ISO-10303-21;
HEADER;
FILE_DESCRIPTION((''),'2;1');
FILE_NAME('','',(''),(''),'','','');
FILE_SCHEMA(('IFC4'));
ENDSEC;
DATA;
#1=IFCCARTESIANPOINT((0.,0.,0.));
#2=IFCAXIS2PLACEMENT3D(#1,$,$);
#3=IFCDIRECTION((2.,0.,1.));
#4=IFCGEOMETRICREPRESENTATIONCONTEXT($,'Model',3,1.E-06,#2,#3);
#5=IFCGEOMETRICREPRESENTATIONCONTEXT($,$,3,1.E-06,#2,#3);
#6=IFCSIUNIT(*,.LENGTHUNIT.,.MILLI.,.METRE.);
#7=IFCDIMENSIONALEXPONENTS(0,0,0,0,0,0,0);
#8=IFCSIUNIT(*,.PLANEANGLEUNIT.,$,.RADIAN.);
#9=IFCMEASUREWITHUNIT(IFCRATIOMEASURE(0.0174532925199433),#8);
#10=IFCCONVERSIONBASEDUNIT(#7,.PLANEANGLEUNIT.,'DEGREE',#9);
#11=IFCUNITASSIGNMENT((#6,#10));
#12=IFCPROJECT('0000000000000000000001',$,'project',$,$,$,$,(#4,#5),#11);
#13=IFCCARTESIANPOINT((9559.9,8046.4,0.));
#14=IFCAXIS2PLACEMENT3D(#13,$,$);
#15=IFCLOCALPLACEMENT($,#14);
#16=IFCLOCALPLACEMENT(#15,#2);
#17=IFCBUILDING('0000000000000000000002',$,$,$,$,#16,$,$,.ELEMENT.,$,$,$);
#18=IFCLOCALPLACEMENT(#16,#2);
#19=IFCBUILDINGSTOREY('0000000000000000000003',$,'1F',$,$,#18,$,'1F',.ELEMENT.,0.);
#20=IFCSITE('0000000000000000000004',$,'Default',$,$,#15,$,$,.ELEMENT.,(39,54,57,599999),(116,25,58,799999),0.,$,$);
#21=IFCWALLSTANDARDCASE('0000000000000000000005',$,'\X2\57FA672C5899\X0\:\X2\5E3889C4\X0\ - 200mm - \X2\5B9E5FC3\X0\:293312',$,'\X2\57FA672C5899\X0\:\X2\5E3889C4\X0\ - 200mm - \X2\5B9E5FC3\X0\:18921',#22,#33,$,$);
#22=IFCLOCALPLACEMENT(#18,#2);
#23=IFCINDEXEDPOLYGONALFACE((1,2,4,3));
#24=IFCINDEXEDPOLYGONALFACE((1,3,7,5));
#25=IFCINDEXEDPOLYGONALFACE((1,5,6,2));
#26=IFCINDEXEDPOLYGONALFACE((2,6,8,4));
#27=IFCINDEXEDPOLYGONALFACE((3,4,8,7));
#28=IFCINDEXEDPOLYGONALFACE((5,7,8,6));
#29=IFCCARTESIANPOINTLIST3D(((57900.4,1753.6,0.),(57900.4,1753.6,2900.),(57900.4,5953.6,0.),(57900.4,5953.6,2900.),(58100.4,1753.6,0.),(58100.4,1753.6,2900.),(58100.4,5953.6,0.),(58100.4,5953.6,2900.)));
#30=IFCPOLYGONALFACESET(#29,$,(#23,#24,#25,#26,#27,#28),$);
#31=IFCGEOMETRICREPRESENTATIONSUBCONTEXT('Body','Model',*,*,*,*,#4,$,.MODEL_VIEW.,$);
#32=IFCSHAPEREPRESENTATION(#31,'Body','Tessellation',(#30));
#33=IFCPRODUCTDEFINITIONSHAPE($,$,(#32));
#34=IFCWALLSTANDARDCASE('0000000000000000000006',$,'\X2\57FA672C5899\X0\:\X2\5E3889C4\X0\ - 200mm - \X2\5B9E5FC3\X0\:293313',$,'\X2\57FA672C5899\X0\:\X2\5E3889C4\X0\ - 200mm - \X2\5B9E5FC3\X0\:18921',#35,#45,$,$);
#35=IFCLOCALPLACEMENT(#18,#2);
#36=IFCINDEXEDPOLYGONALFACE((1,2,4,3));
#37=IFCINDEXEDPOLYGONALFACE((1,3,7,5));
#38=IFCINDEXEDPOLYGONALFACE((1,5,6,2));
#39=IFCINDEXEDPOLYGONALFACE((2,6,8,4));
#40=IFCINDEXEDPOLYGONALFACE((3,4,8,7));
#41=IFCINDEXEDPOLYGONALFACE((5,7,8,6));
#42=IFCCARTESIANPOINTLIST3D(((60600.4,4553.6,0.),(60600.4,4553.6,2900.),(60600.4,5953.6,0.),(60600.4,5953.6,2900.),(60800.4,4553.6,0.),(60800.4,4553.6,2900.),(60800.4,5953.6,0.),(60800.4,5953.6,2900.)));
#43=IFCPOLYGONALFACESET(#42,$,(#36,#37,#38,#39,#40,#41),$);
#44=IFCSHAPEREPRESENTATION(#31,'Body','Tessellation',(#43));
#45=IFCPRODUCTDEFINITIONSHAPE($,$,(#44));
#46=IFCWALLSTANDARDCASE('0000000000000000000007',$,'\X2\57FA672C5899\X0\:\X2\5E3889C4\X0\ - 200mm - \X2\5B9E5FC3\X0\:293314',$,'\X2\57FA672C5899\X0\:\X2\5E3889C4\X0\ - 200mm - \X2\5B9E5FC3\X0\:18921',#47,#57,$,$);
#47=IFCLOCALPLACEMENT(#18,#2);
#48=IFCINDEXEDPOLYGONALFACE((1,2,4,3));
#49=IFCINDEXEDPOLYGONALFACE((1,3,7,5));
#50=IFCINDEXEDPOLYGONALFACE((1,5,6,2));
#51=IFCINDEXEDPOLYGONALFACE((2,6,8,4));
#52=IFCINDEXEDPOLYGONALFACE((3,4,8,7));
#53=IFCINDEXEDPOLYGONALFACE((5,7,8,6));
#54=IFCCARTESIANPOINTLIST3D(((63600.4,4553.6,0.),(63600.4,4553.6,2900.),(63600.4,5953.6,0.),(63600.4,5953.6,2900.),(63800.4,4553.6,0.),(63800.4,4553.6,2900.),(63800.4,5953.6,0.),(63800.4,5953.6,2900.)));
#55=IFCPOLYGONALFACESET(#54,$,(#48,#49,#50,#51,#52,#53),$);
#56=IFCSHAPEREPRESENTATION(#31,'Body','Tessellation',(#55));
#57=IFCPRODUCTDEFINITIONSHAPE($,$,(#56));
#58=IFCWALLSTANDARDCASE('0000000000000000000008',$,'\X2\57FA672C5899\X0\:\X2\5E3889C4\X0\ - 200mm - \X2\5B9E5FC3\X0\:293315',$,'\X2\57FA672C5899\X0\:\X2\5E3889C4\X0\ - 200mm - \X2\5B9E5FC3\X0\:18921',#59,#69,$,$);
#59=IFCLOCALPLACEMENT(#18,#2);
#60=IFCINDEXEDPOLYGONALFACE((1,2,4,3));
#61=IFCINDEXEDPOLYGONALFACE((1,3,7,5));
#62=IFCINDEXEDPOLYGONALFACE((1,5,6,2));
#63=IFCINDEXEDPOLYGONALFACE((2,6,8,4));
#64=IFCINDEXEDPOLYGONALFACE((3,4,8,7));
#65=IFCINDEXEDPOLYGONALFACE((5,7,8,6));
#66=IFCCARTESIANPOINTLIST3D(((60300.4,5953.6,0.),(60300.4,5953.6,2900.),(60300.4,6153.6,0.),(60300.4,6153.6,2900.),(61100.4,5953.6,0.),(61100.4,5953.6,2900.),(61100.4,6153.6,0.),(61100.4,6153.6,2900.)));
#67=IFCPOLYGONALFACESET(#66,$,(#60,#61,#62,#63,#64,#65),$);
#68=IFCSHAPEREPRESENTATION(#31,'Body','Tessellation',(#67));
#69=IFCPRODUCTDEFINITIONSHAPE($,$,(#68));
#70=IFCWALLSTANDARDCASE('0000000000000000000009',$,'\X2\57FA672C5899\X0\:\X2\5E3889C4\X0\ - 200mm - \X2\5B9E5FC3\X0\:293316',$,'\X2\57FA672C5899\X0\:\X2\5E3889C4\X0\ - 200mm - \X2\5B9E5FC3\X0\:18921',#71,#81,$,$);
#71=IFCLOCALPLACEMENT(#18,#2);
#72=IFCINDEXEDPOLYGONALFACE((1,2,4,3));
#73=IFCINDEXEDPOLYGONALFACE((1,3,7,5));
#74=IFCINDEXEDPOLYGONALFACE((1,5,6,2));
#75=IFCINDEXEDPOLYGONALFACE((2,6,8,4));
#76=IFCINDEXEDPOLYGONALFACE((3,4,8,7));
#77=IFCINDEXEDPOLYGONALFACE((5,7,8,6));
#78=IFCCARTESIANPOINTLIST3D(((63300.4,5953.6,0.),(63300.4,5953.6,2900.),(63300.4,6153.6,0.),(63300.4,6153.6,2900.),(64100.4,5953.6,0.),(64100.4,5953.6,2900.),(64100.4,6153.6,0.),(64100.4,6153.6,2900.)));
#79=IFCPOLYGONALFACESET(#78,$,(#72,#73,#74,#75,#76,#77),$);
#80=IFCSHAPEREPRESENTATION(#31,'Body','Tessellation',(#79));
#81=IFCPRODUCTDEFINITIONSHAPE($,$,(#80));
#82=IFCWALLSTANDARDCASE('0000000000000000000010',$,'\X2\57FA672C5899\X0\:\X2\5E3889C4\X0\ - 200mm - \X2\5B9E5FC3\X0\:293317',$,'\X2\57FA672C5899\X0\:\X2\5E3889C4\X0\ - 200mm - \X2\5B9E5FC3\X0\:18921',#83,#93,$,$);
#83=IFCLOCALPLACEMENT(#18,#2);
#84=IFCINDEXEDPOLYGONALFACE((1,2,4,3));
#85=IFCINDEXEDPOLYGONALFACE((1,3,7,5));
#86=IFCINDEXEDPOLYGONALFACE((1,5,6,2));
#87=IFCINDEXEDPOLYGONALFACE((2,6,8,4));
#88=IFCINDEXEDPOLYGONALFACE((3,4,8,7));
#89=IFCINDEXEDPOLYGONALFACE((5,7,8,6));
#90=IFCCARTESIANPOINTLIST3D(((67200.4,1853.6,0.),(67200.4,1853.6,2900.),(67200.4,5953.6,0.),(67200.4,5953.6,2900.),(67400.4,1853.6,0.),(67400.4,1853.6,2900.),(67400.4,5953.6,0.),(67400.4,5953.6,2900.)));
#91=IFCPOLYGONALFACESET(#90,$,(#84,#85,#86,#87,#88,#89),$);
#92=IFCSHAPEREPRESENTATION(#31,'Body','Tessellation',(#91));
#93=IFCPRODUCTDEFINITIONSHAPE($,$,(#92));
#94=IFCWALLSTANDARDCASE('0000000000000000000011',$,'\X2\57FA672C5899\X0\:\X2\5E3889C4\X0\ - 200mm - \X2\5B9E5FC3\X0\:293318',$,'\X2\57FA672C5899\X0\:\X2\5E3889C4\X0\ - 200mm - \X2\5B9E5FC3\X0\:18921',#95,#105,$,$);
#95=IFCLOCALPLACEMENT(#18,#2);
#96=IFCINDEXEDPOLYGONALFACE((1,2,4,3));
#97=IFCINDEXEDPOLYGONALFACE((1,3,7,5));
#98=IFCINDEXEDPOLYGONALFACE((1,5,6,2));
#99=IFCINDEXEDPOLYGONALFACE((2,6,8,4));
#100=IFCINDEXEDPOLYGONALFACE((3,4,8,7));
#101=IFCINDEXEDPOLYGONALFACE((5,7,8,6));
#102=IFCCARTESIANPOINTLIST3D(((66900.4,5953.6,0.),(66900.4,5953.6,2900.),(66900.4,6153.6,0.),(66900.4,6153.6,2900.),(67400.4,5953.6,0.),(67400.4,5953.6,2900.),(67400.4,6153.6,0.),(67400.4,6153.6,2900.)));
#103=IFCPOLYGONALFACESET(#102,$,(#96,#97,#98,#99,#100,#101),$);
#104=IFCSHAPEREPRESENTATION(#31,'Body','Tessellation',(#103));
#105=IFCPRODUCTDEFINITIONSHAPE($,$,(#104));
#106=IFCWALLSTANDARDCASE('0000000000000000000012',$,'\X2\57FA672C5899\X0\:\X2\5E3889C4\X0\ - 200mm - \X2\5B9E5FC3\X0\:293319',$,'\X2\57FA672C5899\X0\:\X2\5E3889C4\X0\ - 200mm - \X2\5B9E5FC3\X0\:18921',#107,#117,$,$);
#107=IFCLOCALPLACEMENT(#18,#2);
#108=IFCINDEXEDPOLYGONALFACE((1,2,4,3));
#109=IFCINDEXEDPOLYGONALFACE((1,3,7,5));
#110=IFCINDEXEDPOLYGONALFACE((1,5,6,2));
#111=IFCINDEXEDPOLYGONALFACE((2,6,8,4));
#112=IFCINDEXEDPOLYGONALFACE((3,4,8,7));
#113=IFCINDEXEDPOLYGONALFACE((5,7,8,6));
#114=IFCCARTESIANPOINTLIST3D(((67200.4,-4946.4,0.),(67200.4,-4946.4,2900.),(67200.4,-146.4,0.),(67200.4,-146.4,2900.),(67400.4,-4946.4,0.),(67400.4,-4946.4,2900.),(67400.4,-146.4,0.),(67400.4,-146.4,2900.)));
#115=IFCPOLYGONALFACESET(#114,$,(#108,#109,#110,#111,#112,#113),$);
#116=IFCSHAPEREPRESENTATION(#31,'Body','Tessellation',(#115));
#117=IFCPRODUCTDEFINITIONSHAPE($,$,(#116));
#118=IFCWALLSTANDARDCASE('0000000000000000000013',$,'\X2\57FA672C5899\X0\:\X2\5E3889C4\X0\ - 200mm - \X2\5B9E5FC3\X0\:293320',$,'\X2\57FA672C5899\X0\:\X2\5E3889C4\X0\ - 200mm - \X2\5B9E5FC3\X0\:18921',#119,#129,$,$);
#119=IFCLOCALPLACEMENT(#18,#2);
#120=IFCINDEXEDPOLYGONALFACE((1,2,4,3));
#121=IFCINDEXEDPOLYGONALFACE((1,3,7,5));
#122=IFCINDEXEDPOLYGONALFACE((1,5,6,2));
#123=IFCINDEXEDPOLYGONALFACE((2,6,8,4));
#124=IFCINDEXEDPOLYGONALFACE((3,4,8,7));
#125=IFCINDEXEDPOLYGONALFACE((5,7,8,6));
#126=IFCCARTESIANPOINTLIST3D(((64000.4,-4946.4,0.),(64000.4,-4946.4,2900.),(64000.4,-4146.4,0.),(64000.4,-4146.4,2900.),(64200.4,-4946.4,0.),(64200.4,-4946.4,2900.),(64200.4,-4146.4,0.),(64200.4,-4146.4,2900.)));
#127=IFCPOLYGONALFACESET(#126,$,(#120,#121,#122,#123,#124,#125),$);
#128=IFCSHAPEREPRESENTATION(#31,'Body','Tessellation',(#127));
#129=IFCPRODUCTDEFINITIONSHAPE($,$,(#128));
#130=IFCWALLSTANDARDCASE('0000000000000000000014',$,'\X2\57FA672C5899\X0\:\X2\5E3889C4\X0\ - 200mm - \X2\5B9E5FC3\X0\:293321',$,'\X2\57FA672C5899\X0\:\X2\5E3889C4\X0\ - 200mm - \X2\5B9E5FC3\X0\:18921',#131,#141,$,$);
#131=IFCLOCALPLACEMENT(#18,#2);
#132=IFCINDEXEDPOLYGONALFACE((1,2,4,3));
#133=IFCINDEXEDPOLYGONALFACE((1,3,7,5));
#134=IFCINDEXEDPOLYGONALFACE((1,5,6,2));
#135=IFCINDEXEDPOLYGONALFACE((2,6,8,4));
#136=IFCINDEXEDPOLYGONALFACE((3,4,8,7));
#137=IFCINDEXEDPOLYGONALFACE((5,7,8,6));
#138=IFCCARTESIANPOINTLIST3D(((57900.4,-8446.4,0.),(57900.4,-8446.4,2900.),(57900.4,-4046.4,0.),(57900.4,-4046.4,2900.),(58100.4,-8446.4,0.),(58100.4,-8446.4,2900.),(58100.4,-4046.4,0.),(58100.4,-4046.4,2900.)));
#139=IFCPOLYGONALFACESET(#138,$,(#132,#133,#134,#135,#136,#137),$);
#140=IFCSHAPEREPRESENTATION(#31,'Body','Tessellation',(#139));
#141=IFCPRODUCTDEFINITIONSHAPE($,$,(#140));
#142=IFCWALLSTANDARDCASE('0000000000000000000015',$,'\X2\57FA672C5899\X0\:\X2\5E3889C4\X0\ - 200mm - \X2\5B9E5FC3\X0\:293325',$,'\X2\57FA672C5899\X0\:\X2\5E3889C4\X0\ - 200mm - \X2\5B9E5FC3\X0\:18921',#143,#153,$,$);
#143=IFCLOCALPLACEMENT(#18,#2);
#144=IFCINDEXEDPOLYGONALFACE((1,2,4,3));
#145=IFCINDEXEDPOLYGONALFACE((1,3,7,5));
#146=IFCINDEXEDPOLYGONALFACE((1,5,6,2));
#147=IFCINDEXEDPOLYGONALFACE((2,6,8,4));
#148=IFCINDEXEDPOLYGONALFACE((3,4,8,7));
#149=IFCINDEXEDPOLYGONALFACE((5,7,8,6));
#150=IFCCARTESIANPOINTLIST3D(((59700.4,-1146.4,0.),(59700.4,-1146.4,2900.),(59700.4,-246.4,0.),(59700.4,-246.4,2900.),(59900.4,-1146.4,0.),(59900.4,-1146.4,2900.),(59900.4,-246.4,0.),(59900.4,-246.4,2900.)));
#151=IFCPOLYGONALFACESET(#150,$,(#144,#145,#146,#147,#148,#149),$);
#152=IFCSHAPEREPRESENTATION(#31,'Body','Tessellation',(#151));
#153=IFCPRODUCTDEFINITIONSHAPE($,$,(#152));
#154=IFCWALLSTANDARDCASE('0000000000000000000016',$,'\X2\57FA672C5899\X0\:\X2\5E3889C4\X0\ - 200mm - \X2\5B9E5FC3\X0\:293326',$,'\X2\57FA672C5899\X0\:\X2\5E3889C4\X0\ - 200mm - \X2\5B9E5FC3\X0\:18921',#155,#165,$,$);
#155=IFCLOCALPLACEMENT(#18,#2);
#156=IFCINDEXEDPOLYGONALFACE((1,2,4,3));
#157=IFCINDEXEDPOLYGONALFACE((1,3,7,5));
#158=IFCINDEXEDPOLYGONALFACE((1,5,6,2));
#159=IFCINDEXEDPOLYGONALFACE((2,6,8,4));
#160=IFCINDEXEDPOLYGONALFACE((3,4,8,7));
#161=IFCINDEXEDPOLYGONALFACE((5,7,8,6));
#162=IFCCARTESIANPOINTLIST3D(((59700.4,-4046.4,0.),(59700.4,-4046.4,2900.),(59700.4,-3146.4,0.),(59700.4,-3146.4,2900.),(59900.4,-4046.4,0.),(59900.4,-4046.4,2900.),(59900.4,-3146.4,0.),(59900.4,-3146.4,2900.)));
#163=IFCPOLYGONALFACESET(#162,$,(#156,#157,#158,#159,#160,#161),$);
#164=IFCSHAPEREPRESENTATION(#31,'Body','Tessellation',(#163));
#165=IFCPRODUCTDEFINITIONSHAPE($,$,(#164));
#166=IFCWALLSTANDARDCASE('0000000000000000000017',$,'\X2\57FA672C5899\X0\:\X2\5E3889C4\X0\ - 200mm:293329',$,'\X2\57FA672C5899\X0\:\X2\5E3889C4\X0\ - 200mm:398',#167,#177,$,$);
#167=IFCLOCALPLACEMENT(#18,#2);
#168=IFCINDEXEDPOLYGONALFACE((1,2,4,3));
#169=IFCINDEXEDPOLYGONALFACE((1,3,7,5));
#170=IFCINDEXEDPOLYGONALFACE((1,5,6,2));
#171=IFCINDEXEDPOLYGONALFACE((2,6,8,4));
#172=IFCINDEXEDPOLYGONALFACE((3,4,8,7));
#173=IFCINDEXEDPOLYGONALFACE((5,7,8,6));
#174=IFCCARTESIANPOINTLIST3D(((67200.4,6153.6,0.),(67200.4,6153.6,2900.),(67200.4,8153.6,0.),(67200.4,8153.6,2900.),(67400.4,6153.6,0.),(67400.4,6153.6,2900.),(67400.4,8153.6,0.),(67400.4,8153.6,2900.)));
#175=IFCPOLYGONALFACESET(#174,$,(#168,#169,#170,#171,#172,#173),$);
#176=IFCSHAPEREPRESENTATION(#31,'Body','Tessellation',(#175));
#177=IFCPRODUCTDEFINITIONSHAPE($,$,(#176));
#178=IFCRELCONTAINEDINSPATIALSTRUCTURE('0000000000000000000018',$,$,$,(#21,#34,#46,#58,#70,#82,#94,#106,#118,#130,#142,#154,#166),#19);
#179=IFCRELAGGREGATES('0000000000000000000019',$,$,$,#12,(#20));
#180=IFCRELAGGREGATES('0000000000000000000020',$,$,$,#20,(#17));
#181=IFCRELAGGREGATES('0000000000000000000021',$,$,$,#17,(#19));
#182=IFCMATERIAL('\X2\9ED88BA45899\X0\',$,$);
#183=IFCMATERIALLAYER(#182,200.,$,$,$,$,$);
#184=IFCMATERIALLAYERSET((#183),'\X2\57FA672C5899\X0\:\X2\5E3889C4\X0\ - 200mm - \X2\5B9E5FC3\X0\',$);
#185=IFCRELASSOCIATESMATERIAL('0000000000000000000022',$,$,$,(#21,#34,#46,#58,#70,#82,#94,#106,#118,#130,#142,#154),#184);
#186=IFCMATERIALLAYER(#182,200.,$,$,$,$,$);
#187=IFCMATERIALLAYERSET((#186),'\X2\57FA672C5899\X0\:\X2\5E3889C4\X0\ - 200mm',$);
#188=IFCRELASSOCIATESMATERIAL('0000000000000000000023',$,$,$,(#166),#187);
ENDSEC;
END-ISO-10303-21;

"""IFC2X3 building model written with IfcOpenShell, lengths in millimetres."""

from ifc_helpers import new_model, entity, si_unit, converted_unit, direction, frame, frame_2d, origin, place, context, subcontext, project, spatial, rectangle, extrude, clip, halfspace, material, layer, layer_set, layer_usage, element, save


model = new_model("IFC2X3")

# Units and contexts
model_context = context("Model", 3, precision=1e-06, world=origin(), true_north=direction((2.0, 0.0, 1.0)))
context_of_model = context(None, 3, precision=1e-06, world=origin(), true_north=direction((2.0, 0.0, 1.0)))
body_context = subcontext(model_context, "Body", "Model", "MODEL_VIEW")
ifc_project = project(units=[si_unit("LENGTHUNIT", "METRE", prefix="MILLI"), converted_unit("PLANEANGLEUNIT", "DEGREE", entity("IfcRatioMeasure", 0.0174532925199433), si_unit("PLANEANGLEUNIT", "RADIAN"), dimensions=[0, 0, 0, 0, 0, 0, 0])], contexts=[model_context, context_of_model])

# Site, building, storey
site_placement = place(None, frame((9559.9, 8046.4, 0.0)))
site = spatial("IfcSite", under=ifc_project, at=site_placement, Name="Default", CompositionType="ELEMENT", RefLatitude=(39, 54, 57, 599999), RefLongitude=(116, 25, 58, 799999), RefElevation=0.0)
building_placement = place(site_placement, origin())
building = spatial("IfcBuilding", under=site, at=building_placement, CompositionType="ELEMENT")
storey_placement = place(building_placement, origin())
storey = spatial("IfcBuildingStorey", under=building, at=storey_placement, Name="1F", LongName="1F", CompositionType="ELEMENT", Elevation=0.0)

# Walls
ifc_material = material(Name="默认墙")
ifc_layer_1 = layer(ifc_material, 200.0)
ifc_layer_set_1 = layer_set([ifc_layer_1], Name="基本墙:常规 - 200mm - 实心")
ifc_layer_usage_1 = layer_usage(ifc_layer_set_1, "AXIS2", "NEGATIVE", 100.0)
wall_1_placement = place(storey_placement, frame((58000.4, 5953.6, 0.0), z_axis=(0.0, 0.0, 1.0), x_axis=(0.0, -1.0, 0.0)))
element("IfcWallStandardCase", 1, at=wall_1_placement, inside=storey, material=ifc_layer_usage_1, Name="基本墙:常规 - 200mm - 实心:293312", ObjectType="基本墙:常规 - 200mm - 实心:18921", context=body_context, shape_type="Clipping", body=[
    clip(extrude(rectangle(XDim=4200.0, YDim=200.0, at=frame_2d((2100.0, 0.0), x_axis=(-1.0, 0.0))), origin(), (0.0, 0.0, 1.0), 2900.0), halfspace(frame((0.0, 0.0, -1400.0)), True)),
])
ifc_layer_usage_2 = layer_usage(ifc_layer_set_1, "AXIS2", "NEGATIVE", 100.0)
wall_2_placement = place(storey_placement, frame((60700.4, 5953.6, 0.0), z_axis=(0.0, 0.0, 1.0), x_axis=(0.0, -1.0, 0.0)))
element("IfcWallStandardCase", 2, at=wall_2_placement, inside=storey, material=ifc_layer_usage_2, Name="基本墙:常规 - 200mm - 实心:293313", ObjectType="基本墙:常规 - 200mm - 实心:18921", context=body_context, shape_type="Clipping", body=[
    clip(extrude(rectangle(XDim=1400.0, YDim=200.0, at=frame_2d((700.0, 0.0), x_axis=(-1.0, 0.0))), origin(), (0.0, 0.0, 1.0), 2900.0), halfspace(frame((0.0, 0.0, -1400.0)), True)),
])
ifc_layer_usage_3 = layer_usage(ifc_layer_set_1, "AXIS2", "NEGATIVE", 100.0)
wall_3_placement = place(storey_placement, frame((63700.4, 5953.6, 0.0), z_axis=(0.0, 0.0, 1.0), x_axis=(0.0, -1.0, 0.0)))
element("IfcWallStandardCase", 3, at=wall_3_placement, inside=storey, material=ifc_layer_usage_3, Name="基本墙:常规 - 200mm - 实心:293314", ObjectType="基本墙:常规 - 200mm - 实心:18921", context=body_context, shape_type="Clipping", body=[
    clip(extrude(rectangle(XDim=1400.0, YDim=200.0, at=frame_2d((700.0, 0.0), x_axis=(-1.0, 0.0))), origin(), (0.0, 0.0, 1.0), 2900.0), halfspace(frame((0.0, 0.0, -1400.0)), True)),
])
ifc_layer_usage_4 = layer_usage(ifc_layer_set_1, "AXIS2", "NEGATIVE", 100.0)
wall_4_placement = place(storey_placement, frame((61100.4, 6053.6, 0.0), z_axis=(0.0, 0.0, 1.0), x_axis=(-1.0, 0.0, 0.0)))
element("IfcWallStandardCase", 4, at=wall_4_placement, inside=storey, material=ifc_layer_usage_4, Name="基本墙:常规 - 200mm - 实心:293315", ObjectType="基本墙:常规 - 200mm - 实心:18921", context=body_context, shape_type="Clipping", body=[
    clip(extrude(rectangle(XDim=800.0, YDim=200.0, at=frame_2d((400.0, 0.0), x_axis=(-1.0, 0.0))), origin(), (0.0, 0.0, 1.0), 2900.0), halfspace(frame((0.0, 0.0, -1400.0)), True)),
])
ifc_layer_usage_5 = layer_usage(ifc_layer_set_1, "AXIS2", "NEGATIVE", 100.0)
wall_5_placement = place(storey_placement, frame((64100.4, 6053.6, 0.0), z_axis=(0.0, 0.0, 1.0), x_axis=(-1.0, 0.0, 0.0)))
element("IfcWallStandardCase", 5, at=wall_5_placement, inside=storey, material=ifc_layer_usage_5, Name="基本墙:常规 - 200mm - 实心:293316", ObjectType="基本墙:常规 - 200mm - 实心:18921", context=body_context, shape_type="Clipping", body=[
    clip(extrude(rectangle(XDim=800.0, YDim=200.0, at=frame_2d((400.0, 0.0), x_axis=(-1.0, 0.0))), origin(), (0.0, 0.0, 1.0), 2900.0), halfspace(frame((0.0, 0.0, -1400.0)), True)),
])
ifc_layer_usage_6 = layer_usage(ifc_layer_set_1, "AXIS2", "NEGATIVE", 100.0)
wall_6_placement = place(storey_placement, frame((67300.4, 5953.6, 0.0), z_axis=(0.0, 0.0, 1.0), x_axis=(0.0, -1.0, 0.0)))
element("IfcWallStandardCase", 6, at=wall_6_placement, inside=storey, material=ifc_layer_usage_6, Name="基本墙:常规 - 200mm - 实心:293317", ObjectType="基本墙:常规 - 200mm - 实心:18921", context=body_context, shape_type="Clipping", body=[
    clip(extrude(rectangle(XDim=4100.0, YDim=200.0, at=frame_2d((2050.0, 0.0), x_axis=(-1.0, 0.0))), origin(), (0.0, 0.0, 1.0), 2900.0), halfspace(frame((0.0, 0.0, -1400.0)), True)),
])
ifc_layer_usage_7 = layer_usage(ifc_layer_set_1, "AXIS2", "NEGATIVE", 100.0)
wall_7_placement = place(storey_placement, frame((67400.4, 6053.6, 0.0), z_axis=(0.0, 0.0, 1.0), x_axis=(-1.0, 0.0, 0.0)))
element("IfcWallStandardCase", 7, at=wall_7_placement, inside=storey, material=ifc_layer_usage_7, Name="基本墙:常规 - 200mm - 实心:293318", ObjectType="基本墙:常规 - 200mm - 实心:18921", context=body_context, shape_type="Clipping", body=[
    clip(extrude(rectangle(XDim=500.0, YDim=200.0, at=frame_2d((250.0, 0.0), x_axis=(-1.0, 0.0))), origin(), (0.0, 0.0, 1.0), 2900.0), halfspace(frame((0.0, 0.0, -1400.0)), True)),
])
ifc_layer_usage_8 = layer_usage(ifc_layer_set_1, "AXIS2", "NEGATIVE", 100.0)
wall_8_placement = place(storey_placement, frame((67300.4, -146.4, 0.0), z_axis=(0.0, 0.0, 1.0), x_axis=(0.0, -1.0, 0.0)))
element("IfcWallStandardCase", 8, at=wall_8_placement, inside=storey, material=ifc_layer_usage_8, Name="基本墙:常规 - 200mm - 实心:293319", ObjectType="基本墙:常规 - 200mm - 实心:18921", context=body_context, shape_type="Clipping", body=[
    clip(extrude(rectangle(XDim=4800.0, YDim=200.0, at=frame_2d((2400.0, 0.0), x_axis=(-1.0, 0.0))), origin(), (0.0, 0.0, 1.0), 2900.0), halfspace(frame((0.0, 0.0, -1400.0)), True)),
])
ifc_layer_usage_9 = layer_usage(ifc_layer_set_1, "AXIS2", "NEGATIVE", 100.0)
wall_9_placement = place(storey_placement, frame((64100.4, -4946.4, 0.0), z_axis=(0.0, 0.0, 1.0), x_axis=(0.0, 1.0, 0.0)))
element("IfcWallStandardCase", 9, at=wall_9_placement, inside=storey, material=ifc_layer_usage_9, Name="基本墙:常规 - 200mm - 实心:293320", ObjectType="基本墙:常规 - 200mm - 实心:18921", context=body_context, shape_type="Clipping", body=[
    clip(extrude(rectangle(XDim=800.0, YDim=200.0, at=frame_2d((400.0, 0.0), x_axis=(-1.0, 0.0))), origin(), (0.0, 0.0, 1.0), 2900.0), halfspace(frame((0.0, 0.0, -1400.0)), True)),
])
ifc_layer_usage_10 = layer_usage(ifc_layer_set_1, "AXIS2", "NEGATIVE", 100.0)
wall_10_placement = place(storey_placement, frame((58000.4, -4046.4, 0.0), z_axis=(0.0, 0.0, 1.0), x_axis=(0.0, -1.0, 0.0)))
element("IfcWallStandardCase", 10, at=wall_10_placement, inside=storey, material=ifc_layer_usage_10, Name="基本墙:常规 - 200mm - 实心:293321", ObjectType="基本墙:常规 - 200mm - 实心:18921", context=body_context, shape_type="Clipping", body=[
    clip(extrude(rectangle(XDim=4400.0, YDim=200.0, at=frame_2d((2200.0, 0.0), x_axis=(-1.0, 0.0))), origin(), (0.0, 0.0, 1.0), 2900.0), halfspace(frame((0.0, 0.0, -1400.0)), True)),
])
ifc_layer_usage_11 = layer_usage(ifc_layer_set_1, "AXIS2", "NEGATIVE", 100.0)
wall_11_placement = place(storey_placement, frame((59800.4, -246.4, 0.0), z_axis=(0.0, 0.0, 1.0), x_axis=(0.0, -1.0, 0.0)))
element("IfcWallStandardCase", 11, at=wall_11_placement, inside=storey, material=ifc_layer_usage_11, Name="基本墙:常规 - 200mm - 实心:293325", ObjectType="基本墙:常规 - 200mm - 实心:18921", context=body_context, shape_type="Clipping", body=[
    clip(extrude(rectangle(XDim=900.0, YDim=200.0, at=frame_2d((450.0, 0.0), x_axis=(-1.0, 0.0))), origin(), (0.0, 0.0, 1.0), 2900.0), halfspace(frame((0.0, 0.0, -1400.0)), True)),
])
ifc_layer_usage_12 = layer_usage(ifc_layer_set_1, "AXIS2", "NEGATIVE", 100.0)
wall_12_placement = place(storey_placement, frame((59800.4, -4046.4, 0.0), z_axis=(0.0, 0.0, 1.0), x_axis=(0.0, 1.0, 0.0)))
element("IfcWallStandardCase", 12, at=wall_12_placement, inside=storey, material=ifc_layer_usage_12, Name="基本墙:常规 - 200mm - 实心:293326", ObjectType="基本墙:常规 - 200mm - 实心:18921", context=body_context, shape_type="Clipping", body=[
    clip(extrude(rectangle(XDim=900.0, YDim=200.0, at=frame_2d((450.0, 0.0), x_axis=(-1.0, 0.0))), origin(), (0.0, 0.0, 1.0), 2900.0), halfspace(frame((0.0, 0.0, -1400.0)), True)),
])
ifc_layer_2 = layer(ifc_material, 200.0)
ifc_layer_set_2 = layer_set([ifc_layer_2], Name="基本墙:常规 - 200mm")
ifc_layer_usage_13 = layer_usage(ifc_layer_set_2, "AXIS2", "NEGATIVE", 100.0)
wall_13_placement = place(storey_placement, frame((67300.4, 8153.6, 0.0), z_axis=(0.0, 0.0, 1.0), x_axis=(0.0, -1.0, 0.0)))
element("IfcWallStandardCase", 13, at=wall_13_placement, inside=storey, material=ifc_layer_usage_13, Name="基本墙:常规 - 200mm:293329", ObjectType="基本墙:常规 - 200mm:398", context=body_context, shape_type="Clipping", body=[
    clip(extrude(rectangle(XDim=2000.0, YDim=200.0, at=frame_2d((1000.0, 0.0), x_axis=(-1.0, 0.0))), origin(), (0.0, 0.0, 1.0), 2900.0), halfspace(frame((0.0, 0.0, -1400.0)), True)),
])

save(model, "model.ifc")
